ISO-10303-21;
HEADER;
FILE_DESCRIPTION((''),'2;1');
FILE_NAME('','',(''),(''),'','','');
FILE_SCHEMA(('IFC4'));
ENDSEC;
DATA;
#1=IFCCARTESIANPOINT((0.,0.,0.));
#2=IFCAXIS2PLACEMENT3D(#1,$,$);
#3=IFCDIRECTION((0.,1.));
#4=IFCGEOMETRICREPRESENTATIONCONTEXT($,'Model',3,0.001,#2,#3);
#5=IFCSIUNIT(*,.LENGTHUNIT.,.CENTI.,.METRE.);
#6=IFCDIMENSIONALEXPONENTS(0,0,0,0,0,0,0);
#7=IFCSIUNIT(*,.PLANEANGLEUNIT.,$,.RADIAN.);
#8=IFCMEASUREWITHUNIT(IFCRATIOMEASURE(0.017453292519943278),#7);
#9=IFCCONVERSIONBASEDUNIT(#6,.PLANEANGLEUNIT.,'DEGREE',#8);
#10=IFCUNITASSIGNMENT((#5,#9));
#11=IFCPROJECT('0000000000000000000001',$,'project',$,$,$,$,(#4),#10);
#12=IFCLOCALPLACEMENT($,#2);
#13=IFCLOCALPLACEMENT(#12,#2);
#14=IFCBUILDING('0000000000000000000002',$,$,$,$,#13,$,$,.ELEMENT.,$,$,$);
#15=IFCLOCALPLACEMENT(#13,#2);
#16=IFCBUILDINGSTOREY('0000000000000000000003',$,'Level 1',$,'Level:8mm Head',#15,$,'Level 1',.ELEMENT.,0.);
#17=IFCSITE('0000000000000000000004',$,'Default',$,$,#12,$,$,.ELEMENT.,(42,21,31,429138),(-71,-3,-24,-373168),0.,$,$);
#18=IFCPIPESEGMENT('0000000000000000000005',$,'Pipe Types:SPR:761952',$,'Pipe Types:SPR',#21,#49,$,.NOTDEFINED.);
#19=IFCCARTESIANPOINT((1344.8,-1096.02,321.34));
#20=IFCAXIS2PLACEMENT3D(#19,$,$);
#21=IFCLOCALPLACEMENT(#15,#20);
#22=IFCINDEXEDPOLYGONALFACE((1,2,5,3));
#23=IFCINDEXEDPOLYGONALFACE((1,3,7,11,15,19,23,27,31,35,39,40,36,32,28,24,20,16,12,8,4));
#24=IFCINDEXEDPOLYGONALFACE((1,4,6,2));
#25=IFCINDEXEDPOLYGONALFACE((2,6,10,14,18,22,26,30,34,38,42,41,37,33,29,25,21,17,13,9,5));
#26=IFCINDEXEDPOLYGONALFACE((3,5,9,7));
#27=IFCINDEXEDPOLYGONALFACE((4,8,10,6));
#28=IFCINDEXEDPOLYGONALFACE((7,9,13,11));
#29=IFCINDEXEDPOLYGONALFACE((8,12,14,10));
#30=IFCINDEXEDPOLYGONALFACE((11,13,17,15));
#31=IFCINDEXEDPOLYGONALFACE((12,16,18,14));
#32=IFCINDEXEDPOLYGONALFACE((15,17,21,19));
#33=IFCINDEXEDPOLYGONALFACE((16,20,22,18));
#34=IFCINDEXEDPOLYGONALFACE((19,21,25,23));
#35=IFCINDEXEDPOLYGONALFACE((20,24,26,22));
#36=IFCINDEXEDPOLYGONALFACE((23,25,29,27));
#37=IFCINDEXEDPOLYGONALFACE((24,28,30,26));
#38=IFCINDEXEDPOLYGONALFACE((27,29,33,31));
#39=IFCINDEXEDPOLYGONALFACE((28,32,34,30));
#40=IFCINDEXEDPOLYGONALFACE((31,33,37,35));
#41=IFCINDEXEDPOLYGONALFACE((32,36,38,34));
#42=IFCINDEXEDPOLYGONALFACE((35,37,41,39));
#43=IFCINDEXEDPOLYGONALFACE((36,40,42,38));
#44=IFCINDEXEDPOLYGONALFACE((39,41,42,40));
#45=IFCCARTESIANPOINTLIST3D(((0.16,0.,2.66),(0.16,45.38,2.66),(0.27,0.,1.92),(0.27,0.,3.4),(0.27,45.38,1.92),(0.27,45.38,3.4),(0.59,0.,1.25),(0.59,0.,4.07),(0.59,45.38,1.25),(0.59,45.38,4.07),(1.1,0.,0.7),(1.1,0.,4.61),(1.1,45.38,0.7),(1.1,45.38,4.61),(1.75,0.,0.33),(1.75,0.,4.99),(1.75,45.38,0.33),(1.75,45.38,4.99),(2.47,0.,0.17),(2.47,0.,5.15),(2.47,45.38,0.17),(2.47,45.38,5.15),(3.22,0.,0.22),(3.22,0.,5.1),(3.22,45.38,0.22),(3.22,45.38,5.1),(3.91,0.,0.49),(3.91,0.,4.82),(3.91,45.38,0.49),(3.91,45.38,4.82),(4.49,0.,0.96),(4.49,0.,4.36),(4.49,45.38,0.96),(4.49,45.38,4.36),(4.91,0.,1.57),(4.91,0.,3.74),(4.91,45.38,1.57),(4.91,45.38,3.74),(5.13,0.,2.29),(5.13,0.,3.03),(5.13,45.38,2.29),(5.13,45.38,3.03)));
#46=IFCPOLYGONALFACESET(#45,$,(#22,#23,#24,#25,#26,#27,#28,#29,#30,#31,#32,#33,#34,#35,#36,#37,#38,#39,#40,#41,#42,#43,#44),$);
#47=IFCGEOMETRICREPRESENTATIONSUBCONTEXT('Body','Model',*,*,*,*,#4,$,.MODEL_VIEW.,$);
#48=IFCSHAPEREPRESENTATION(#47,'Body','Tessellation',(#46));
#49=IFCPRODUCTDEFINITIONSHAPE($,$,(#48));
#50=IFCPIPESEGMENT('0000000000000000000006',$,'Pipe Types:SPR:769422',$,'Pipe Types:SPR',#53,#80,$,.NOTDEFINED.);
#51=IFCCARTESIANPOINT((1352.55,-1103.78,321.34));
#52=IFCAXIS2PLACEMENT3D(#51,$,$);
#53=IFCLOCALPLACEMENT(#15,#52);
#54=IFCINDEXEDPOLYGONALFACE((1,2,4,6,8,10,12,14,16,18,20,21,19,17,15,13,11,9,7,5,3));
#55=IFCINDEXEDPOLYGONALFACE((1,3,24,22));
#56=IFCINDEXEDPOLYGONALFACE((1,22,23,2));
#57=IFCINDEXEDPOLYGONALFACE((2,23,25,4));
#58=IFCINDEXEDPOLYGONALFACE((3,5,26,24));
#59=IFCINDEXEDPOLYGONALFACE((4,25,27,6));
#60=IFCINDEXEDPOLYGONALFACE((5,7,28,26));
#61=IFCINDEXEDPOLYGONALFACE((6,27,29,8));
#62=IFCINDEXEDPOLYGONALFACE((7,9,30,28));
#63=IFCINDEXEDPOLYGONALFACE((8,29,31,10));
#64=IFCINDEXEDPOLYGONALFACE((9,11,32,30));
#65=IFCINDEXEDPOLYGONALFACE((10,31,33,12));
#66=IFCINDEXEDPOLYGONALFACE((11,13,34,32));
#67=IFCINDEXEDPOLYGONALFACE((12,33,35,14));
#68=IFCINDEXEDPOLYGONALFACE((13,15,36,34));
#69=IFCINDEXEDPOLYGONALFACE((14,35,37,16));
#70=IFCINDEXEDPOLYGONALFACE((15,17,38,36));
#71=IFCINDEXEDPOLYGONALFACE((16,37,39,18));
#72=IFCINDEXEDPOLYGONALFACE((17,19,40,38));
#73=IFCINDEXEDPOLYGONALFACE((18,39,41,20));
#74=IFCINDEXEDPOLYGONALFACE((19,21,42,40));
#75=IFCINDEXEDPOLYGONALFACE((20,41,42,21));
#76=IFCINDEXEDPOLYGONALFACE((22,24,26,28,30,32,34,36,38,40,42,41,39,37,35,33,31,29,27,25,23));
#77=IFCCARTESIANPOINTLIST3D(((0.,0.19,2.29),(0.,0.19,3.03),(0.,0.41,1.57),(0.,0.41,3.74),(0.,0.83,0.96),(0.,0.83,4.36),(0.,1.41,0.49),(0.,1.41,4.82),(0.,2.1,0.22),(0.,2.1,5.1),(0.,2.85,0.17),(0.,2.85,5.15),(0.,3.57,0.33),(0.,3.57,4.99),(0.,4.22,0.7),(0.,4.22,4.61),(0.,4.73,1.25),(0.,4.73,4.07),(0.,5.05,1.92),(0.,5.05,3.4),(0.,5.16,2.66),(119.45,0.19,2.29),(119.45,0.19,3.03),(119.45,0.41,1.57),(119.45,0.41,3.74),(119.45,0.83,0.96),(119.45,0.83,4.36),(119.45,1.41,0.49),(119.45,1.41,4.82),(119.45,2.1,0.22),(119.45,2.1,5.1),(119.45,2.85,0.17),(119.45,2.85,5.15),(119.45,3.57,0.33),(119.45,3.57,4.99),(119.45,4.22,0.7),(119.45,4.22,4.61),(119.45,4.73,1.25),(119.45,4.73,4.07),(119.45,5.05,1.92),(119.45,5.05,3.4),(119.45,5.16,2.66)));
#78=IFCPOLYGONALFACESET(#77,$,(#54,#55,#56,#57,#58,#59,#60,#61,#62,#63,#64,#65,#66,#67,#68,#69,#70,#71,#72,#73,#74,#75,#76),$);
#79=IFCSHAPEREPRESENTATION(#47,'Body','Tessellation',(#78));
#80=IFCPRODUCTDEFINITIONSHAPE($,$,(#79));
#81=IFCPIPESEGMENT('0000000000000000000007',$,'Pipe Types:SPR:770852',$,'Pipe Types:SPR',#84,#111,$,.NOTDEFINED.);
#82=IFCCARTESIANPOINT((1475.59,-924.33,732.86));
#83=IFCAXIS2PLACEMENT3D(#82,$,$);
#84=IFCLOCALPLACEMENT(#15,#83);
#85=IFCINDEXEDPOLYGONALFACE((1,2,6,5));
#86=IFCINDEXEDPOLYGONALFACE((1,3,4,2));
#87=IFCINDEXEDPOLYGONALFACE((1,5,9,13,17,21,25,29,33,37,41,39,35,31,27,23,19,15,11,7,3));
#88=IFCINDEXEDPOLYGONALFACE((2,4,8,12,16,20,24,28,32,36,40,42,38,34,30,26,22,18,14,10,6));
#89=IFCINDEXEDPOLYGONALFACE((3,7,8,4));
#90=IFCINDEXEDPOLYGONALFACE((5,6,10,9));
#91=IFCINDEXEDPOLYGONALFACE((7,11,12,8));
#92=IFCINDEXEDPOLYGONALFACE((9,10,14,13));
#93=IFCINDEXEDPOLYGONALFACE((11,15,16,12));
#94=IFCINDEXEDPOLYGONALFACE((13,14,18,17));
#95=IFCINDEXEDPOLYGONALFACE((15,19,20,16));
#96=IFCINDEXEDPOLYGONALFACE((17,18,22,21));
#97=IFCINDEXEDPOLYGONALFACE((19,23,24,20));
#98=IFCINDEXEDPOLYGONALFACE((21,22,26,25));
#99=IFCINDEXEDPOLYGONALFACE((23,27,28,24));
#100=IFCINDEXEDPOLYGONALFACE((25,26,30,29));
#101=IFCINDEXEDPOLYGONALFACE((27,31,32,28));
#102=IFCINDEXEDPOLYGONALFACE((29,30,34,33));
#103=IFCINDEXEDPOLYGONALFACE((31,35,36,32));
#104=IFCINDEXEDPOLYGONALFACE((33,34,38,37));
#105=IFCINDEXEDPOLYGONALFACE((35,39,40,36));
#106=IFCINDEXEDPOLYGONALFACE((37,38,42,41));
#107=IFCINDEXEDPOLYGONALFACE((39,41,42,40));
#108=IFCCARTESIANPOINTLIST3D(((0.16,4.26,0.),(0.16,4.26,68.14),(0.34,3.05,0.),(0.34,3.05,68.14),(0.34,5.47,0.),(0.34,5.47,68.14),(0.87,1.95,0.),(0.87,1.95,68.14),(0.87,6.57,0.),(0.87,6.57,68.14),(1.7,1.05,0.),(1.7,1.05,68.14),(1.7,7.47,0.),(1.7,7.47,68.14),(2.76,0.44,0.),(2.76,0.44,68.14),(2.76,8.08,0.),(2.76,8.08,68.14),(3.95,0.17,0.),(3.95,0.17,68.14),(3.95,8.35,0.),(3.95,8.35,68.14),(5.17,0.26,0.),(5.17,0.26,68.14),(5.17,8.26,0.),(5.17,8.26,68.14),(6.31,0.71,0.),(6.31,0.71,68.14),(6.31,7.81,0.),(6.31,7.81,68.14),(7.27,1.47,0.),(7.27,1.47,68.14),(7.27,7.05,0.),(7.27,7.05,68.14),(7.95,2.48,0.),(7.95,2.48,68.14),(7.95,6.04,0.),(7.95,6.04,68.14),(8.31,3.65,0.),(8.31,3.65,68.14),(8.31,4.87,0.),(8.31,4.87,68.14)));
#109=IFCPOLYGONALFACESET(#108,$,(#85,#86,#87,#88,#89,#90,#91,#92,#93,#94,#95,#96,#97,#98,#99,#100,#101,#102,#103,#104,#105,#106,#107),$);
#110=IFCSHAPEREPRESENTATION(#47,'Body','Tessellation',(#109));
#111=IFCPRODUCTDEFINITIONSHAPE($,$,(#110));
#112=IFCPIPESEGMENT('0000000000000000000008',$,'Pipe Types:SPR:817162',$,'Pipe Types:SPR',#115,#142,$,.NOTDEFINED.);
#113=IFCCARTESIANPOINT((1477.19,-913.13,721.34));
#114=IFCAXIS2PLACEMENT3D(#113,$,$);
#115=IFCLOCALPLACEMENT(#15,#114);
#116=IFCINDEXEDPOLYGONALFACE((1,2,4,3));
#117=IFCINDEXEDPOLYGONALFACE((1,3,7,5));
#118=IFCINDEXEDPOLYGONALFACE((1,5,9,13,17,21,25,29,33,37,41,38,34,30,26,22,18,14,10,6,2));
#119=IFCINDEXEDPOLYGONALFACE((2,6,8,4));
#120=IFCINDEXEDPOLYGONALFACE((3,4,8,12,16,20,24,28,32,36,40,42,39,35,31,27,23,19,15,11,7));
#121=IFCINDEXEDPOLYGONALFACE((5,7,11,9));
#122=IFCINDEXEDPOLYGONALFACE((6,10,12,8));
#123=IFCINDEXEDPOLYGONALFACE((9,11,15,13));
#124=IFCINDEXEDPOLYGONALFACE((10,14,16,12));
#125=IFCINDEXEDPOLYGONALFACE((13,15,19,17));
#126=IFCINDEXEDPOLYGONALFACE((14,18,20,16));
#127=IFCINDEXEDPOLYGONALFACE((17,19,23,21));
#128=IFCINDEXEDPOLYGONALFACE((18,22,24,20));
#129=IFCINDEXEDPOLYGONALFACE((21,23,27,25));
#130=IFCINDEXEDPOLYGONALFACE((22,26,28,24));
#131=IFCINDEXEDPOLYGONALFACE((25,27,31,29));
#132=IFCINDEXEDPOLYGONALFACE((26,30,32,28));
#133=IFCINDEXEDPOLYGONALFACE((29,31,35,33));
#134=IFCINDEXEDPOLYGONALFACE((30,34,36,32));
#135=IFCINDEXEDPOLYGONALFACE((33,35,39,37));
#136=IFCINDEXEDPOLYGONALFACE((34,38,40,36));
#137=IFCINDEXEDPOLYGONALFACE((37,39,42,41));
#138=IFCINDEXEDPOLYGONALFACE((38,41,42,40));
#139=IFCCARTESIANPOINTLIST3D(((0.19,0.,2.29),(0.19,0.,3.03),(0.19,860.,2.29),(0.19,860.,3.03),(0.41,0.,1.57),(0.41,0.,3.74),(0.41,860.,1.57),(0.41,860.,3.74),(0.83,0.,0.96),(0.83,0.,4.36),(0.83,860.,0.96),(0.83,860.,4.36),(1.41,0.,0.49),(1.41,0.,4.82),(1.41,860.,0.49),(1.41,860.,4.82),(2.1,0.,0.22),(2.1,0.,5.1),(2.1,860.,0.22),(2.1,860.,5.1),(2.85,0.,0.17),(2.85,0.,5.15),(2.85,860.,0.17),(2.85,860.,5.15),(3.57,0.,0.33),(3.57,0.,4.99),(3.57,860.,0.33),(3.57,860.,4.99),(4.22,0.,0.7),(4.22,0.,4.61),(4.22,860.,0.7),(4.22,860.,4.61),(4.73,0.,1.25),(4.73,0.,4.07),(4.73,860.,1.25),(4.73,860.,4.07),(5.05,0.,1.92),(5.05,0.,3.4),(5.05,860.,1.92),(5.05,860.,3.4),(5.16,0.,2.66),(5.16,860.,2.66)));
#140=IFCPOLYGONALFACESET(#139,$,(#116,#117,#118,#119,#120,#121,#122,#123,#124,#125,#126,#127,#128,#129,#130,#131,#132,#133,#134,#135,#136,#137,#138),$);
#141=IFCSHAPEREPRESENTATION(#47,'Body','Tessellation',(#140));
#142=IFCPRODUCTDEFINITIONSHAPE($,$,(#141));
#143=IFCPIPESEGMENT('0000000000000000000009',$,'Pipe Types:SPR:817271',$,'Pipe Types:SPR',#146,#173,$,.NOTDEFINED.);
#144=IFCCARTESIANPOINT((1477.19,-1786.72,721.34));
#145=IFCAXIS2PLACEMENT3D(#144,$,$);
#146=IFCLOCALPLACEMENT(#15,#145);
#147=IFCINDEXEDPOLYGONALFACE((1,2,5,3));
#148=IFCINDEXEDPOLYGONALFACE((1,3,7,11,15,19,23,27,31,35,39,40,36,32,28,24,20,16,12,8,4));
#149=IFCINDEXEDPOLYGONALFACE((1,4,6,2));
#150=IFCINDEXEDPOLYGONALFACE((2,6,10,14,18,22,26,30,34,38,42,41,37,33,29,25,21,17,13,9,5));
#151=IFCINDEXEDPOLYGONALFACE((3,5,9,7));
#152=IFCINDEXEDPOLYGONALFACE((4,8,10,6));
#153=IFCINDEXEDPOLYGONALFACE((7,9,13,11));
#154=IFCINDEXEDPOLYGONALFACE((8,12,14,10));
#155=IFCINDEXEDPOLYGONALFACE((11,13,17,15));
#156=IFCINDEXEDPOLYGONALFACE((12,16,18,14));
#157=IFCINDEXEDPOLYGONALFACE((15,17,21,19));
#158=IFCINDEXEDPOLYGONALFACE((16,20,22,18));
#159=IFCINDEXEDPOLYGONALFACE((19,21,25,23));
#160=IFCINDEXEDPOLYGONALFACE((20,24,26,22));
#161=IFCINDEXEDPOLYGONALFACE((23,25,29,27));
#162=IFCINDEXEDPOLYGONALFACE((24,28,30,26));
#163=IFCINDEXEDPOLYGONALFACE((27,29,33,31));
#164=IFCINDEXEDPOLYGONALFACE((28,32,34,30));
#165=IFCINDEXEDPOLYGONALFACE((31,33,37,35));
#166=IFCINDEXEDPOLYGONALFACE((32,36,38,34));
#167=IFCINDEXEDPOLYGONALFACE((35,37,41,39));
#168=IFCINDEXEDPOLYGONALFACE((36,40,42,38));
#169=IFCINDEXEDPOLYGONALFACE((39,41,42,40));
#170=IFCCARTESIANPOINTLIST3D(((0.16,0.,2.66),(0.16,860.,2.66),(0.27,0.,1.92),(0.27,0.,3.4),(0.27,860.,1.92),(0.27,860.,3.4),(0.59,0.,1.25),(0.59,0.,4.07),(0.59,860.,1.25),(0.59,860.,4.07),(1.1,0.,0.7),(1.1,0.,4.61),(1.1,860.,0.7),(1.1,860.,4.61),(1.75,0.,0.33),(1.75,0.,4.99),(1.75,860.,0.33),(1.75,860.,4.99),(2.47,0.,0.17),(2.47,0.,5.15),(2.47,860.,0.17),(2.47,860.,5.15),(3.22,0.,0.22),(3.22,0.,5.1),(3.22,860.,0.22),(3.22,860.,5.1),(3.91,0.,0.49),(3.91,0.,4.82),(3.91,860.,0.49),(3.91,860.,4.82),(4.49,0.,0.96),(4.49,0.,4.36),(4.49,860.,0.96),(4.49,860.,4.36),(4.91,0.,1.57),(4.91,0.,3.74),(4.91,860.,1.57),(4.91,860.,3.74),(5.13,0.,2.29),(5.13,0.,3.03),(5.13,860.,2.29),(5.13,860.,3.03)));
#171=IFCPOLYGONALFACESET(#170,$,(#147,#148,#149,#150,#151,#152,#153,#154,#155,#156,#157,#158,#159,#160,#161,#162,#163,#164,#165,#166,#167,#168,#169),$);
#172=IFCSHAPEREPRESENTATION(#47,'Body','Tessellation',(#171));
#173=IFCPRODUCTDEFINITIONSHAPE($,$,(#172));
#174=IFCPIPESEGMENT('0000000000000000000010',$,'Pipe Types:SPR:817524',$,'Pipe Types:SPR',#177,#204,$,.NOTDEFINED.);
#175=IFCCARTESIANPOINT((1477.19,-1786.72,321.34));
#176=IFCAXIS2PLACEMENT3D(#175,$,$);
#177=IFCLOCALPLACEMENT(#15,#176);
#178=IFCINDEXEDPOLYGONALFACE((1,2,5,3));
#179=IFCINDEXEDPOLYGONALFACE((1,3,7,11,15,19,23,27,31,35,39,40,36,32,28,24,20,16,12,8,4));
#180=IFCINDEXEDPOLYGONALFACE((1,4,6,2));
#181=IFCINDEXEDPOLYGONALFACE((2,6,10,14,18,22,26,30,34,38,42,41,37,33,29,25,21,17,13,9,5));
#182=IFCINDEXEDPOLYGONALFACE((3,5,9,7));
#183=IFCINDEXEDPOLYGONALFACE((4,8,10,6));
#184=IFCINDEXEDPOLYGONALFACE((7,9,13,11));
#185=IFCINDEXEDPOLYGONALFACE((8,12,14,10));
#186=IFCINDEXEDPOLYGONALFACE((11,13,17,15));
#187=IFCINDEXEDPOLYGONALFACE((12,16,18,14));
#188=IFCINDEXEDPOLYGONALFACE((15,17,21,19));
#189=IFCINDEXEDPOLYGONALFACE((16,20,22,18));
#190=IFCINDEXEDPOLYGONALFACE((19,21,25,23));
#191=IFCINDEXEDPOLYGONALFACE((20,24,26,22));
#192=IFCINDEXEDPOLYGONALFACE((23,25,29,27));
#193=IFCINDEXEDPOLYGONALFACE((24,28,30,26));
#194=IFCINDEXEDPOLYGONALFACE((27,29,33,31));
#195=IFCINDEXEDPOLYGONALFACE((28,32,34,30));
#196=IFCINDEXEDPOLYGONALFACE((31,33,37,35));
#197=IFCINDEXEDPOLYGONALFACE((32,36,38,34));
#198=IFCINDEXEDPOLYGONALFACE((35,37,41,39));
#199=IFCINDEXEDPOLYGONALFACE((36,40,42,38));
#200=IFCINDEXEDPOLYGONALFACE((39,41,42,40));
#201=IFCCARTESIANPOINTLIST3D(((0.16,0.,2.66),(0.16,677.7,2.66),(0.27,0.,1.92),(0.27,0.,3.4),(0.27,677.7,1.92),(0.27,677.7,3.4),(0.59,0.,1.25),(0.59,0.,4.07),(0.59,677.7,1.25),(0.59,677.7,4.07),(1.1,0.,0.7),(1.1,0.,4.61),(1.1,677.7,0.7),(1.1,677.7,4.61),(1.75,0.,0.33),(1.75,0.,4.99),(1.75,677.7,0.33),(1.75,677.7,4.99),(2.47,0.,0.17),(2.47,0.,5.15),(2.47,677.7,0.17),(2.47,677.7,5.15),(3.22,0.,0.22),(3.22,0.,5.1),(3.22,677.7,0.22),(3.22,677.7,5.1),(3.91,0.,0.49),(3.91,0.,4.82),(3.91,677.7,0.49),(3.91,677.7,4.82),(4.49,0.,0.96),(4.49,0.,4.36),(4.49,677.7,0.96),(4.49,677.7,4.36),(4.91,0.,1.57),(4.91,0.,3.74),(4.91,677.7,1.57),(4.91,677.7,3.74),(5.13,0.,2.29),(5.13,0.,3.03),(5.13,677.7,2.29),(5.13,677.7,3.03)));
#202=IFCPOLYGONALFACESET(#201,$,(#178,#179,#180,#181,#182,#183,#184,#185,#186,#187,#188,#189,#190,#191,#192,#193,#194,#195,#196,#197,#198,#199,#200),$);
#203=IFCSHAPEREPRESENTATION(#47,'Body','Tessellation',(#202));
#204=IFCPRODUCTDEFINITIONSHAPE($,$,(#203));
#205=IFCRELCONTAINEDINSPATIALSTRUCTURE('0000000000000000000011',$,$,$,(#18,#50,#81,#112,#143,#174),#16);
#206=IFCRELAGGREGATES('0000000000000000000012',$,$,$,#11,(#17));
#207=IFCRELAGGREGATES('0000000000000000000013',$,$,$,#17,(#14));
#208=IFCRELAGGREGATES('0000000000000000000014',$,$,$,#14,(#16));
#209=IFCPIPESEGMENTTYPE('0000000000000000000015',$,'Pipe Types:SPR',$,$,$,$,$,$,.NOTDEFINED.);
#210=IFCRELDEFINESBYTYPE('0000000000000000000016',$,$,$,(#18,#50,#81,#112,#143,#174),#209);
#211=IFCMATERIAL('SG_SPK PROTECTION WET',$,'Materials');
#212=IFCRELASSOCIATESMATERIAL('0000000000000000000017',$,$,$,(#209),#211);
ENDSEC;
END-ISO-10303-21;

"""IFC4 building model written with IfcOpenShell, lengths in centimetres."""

from ifc_helpers import new_model, entity, si_unit, converted_unit, direction, frame, frame_2d, origin, origin_2d_with_axis, place, context, subcontext, project, spatial, circle, extrude, material, type_object, element, save


model = new_model("IFC4")

# Units and contexts
model_context = context("Model", 3, precision=0.001, world=origin(), true_north=direction((0.0, 1.0)))
body_context = subcontext(model_context, "Body", "Model", "MODEL_VIEW")
ifc_project = project(units=[si_unit("LENGTHUNIT", "METRE", prefix="CENTI"), converted_unit("PLANEANGLEUNIT", "DEGREE", entity("IfcRatioMeasure", 0.017453292519943278), si_unit("PLANEANGLEUNIT", "RADIAN"), dimensions=[0, 0, 0, 0, 0, 0, 0])], contexts=[model_context])

# Site, building, storey
site_placement = place(None, origin())
site = spatial("IfcSite", under=ifc_project, at=site_placement, Name="Default", CompositionType="ELEMENT", RefLatitude=(42, 21, 31, 429138), RefLongitude=(-71, -3, -24, -373168), RefElevation=0.0)
building_placement = place(site_placement, origin())
building = spatial("IfcBuilding", under=site, at=building_placement, CompositionType="ELEMENT")
storey_placement = place(building_placement, origin())
storey = spatial("IfcBuildingStorey", under=building, at=storey_placement, Name="Level 1", ObjectType="Level:8mm Head", LongName="Level 1", CompositionType="ELEMENT", Elevation=0.0)

# Pipe segments
ifc_material_1 = material(Name="SG_SPK PROTECTION WET", Category="Materials")
pipe_segment_type = type_object("IfcPipeSegmentType", Name="Pipe Types:SPR", PredefinedType="NOTDEFINED", material=ifc_material_1)
pipe_segment_1_placement = place(storey_placement, frame((1344.8, -1096.02, 321.34)))
element("IfcPipeSegment", 1, at=pipe_segment_1_placement, inside=storey, type_object=pipe_segment_type, Name="Pipe Types:SPR:761952", ObjectType="Pipe Types:SPR", PredefinedType="NOTDEFINED", context=body_context, shape_type="SweptSolid", body=[
    extrude(circle(Radius=2.5, at=frame_2d((0.0, 0.0), x_axis=(1.0, 0.0))), frame((2.66, 0.0, 2.66), z_axis=(0.0, 1.0, 0.0), x_axis=(-1.0, 0.0, 0.0)), (0.0, 0.0, 1.0), 45.38),
])
pipe_segment_2_placement = place(storey_placement, frame((1352.55, -1103.78, 321.34)))
element("IfcPipeSegment", 2, at=pipe_segment_2_placement, inside=storey, type_object=pipe_segment_type, Name="Pipe Types:SPR:769422", ObjectType="Pipe Types:SPR", PredefinedType="NOTDEFINED", context=body_context, shape_type="SweptSolid", body=[
    extrude(circle(Radius=2.5, at=frame_2d((0.0, 0.0), x_axis=(1.0, 0.0))), frame((0.0, 2.66, 2.66), z_axis=(1.0, 0.0, 0.0), x_axis=(0.0, 1.0, 0.0)), (0.0, 0.0, 1.0), 119.45),
])
pipe_segment_3_placement = place(storey_placement, frame((1475.59, -924.33, 732.86)))
element("IfcPipeSegment", 3, at=pipe_segment_3_placement, inside=storey, type_object=pipe_segment_type, Name="Pipe Types:SPR:770852", ObjectType="Pipe Types:SPR", PredefinedType="NOTDEFINED", context=body_context, shape_type="SweptSolid", body=[
    extrude(circle(Radius=4.1, at=frame_2d((0.0, 0.0), x_axis=(1.0, 0.0))), frame((4.26, 4.26, 0.0), z_axis=(0.0, 0.0, 1.0), x_axis=(-1.0, 0.0, 0.0)), (0.0, 0.0, 1.0), 68.14),
])
pipe_segment_4_placement = place(storey_placement, frame((1477.19, -913.13, 721.34)))
element("IfcPipeSegment", 4, at=pipe_segment_4_placement, inside=storey, type_object=pipe_segment_type, Name="Pipe Types:SPR:817162", ObjectType="Pipe Types:SPR", PredefinedType="NOTDEFINED", context=body_context, shape_type="SweptSolid", body=[
    extrude(circle(Radius=2.5, at=frame_2d((0.0, 0.0), x_axis=(1.0, 0.0))), frame((2.66, 0.0, 2.66), z_axis=(0.0, 1.0, 0.0), x_axis=(1.0, 0.0, 0.0)), (0.0, 0.0, 1.0), 860.0),
])
pipe_segment_5_placement = place(storey_placement, frame((1477.19, -1786.72, 721.34)))
element("IfcPipeSegment", 5, at=pipe_segment_5_placement, inside=storey, type_object=pipe_segment_type, Name="Pipe Types:SPR:817271", ObjectType="Pipe Types:SPR", PredefinedType="NOTDEFINED", context=body_context, shape_type="SweptSolid", body=[
    extrude(circle(Radius=2.5, at=frame_2d((0.0, 0.0), x_axis=(1.0, 0.0))), frame((2.66, 0.0, 2.66), z_axis=(0.0, 1.0, 0.0), x_axis=(-1.0, 0.0, 0.0)), (0.0, 0.0, 1.0), 860.0),
])
pipe_segment_6_placement = place(storey_placement, frame((1477.19, -1786.72, 321.34)))
element("IfcPipeSegment", 6, at=pipe_segment_6_placement, inside=storey, type_object=pipe_segment_type, Name="Pipe Types:SPR:817524", ObjectType="Pipe Types:SPR", PredefinedType="NOTDEFINED", context=body_context, shape_type="SweptSolid", body=[
    extrude(circle(Radius=2.5, at=origin_2d_with_axis()), frame((2.66, 0.0, 2.66), z_axis=(0.0, 1.0, 0.0), x_axis=(-1.0, 0.0, 0.0)), (0.0, 0.0, 1.0), 677.7),
])

save(model, "model.ifc")
